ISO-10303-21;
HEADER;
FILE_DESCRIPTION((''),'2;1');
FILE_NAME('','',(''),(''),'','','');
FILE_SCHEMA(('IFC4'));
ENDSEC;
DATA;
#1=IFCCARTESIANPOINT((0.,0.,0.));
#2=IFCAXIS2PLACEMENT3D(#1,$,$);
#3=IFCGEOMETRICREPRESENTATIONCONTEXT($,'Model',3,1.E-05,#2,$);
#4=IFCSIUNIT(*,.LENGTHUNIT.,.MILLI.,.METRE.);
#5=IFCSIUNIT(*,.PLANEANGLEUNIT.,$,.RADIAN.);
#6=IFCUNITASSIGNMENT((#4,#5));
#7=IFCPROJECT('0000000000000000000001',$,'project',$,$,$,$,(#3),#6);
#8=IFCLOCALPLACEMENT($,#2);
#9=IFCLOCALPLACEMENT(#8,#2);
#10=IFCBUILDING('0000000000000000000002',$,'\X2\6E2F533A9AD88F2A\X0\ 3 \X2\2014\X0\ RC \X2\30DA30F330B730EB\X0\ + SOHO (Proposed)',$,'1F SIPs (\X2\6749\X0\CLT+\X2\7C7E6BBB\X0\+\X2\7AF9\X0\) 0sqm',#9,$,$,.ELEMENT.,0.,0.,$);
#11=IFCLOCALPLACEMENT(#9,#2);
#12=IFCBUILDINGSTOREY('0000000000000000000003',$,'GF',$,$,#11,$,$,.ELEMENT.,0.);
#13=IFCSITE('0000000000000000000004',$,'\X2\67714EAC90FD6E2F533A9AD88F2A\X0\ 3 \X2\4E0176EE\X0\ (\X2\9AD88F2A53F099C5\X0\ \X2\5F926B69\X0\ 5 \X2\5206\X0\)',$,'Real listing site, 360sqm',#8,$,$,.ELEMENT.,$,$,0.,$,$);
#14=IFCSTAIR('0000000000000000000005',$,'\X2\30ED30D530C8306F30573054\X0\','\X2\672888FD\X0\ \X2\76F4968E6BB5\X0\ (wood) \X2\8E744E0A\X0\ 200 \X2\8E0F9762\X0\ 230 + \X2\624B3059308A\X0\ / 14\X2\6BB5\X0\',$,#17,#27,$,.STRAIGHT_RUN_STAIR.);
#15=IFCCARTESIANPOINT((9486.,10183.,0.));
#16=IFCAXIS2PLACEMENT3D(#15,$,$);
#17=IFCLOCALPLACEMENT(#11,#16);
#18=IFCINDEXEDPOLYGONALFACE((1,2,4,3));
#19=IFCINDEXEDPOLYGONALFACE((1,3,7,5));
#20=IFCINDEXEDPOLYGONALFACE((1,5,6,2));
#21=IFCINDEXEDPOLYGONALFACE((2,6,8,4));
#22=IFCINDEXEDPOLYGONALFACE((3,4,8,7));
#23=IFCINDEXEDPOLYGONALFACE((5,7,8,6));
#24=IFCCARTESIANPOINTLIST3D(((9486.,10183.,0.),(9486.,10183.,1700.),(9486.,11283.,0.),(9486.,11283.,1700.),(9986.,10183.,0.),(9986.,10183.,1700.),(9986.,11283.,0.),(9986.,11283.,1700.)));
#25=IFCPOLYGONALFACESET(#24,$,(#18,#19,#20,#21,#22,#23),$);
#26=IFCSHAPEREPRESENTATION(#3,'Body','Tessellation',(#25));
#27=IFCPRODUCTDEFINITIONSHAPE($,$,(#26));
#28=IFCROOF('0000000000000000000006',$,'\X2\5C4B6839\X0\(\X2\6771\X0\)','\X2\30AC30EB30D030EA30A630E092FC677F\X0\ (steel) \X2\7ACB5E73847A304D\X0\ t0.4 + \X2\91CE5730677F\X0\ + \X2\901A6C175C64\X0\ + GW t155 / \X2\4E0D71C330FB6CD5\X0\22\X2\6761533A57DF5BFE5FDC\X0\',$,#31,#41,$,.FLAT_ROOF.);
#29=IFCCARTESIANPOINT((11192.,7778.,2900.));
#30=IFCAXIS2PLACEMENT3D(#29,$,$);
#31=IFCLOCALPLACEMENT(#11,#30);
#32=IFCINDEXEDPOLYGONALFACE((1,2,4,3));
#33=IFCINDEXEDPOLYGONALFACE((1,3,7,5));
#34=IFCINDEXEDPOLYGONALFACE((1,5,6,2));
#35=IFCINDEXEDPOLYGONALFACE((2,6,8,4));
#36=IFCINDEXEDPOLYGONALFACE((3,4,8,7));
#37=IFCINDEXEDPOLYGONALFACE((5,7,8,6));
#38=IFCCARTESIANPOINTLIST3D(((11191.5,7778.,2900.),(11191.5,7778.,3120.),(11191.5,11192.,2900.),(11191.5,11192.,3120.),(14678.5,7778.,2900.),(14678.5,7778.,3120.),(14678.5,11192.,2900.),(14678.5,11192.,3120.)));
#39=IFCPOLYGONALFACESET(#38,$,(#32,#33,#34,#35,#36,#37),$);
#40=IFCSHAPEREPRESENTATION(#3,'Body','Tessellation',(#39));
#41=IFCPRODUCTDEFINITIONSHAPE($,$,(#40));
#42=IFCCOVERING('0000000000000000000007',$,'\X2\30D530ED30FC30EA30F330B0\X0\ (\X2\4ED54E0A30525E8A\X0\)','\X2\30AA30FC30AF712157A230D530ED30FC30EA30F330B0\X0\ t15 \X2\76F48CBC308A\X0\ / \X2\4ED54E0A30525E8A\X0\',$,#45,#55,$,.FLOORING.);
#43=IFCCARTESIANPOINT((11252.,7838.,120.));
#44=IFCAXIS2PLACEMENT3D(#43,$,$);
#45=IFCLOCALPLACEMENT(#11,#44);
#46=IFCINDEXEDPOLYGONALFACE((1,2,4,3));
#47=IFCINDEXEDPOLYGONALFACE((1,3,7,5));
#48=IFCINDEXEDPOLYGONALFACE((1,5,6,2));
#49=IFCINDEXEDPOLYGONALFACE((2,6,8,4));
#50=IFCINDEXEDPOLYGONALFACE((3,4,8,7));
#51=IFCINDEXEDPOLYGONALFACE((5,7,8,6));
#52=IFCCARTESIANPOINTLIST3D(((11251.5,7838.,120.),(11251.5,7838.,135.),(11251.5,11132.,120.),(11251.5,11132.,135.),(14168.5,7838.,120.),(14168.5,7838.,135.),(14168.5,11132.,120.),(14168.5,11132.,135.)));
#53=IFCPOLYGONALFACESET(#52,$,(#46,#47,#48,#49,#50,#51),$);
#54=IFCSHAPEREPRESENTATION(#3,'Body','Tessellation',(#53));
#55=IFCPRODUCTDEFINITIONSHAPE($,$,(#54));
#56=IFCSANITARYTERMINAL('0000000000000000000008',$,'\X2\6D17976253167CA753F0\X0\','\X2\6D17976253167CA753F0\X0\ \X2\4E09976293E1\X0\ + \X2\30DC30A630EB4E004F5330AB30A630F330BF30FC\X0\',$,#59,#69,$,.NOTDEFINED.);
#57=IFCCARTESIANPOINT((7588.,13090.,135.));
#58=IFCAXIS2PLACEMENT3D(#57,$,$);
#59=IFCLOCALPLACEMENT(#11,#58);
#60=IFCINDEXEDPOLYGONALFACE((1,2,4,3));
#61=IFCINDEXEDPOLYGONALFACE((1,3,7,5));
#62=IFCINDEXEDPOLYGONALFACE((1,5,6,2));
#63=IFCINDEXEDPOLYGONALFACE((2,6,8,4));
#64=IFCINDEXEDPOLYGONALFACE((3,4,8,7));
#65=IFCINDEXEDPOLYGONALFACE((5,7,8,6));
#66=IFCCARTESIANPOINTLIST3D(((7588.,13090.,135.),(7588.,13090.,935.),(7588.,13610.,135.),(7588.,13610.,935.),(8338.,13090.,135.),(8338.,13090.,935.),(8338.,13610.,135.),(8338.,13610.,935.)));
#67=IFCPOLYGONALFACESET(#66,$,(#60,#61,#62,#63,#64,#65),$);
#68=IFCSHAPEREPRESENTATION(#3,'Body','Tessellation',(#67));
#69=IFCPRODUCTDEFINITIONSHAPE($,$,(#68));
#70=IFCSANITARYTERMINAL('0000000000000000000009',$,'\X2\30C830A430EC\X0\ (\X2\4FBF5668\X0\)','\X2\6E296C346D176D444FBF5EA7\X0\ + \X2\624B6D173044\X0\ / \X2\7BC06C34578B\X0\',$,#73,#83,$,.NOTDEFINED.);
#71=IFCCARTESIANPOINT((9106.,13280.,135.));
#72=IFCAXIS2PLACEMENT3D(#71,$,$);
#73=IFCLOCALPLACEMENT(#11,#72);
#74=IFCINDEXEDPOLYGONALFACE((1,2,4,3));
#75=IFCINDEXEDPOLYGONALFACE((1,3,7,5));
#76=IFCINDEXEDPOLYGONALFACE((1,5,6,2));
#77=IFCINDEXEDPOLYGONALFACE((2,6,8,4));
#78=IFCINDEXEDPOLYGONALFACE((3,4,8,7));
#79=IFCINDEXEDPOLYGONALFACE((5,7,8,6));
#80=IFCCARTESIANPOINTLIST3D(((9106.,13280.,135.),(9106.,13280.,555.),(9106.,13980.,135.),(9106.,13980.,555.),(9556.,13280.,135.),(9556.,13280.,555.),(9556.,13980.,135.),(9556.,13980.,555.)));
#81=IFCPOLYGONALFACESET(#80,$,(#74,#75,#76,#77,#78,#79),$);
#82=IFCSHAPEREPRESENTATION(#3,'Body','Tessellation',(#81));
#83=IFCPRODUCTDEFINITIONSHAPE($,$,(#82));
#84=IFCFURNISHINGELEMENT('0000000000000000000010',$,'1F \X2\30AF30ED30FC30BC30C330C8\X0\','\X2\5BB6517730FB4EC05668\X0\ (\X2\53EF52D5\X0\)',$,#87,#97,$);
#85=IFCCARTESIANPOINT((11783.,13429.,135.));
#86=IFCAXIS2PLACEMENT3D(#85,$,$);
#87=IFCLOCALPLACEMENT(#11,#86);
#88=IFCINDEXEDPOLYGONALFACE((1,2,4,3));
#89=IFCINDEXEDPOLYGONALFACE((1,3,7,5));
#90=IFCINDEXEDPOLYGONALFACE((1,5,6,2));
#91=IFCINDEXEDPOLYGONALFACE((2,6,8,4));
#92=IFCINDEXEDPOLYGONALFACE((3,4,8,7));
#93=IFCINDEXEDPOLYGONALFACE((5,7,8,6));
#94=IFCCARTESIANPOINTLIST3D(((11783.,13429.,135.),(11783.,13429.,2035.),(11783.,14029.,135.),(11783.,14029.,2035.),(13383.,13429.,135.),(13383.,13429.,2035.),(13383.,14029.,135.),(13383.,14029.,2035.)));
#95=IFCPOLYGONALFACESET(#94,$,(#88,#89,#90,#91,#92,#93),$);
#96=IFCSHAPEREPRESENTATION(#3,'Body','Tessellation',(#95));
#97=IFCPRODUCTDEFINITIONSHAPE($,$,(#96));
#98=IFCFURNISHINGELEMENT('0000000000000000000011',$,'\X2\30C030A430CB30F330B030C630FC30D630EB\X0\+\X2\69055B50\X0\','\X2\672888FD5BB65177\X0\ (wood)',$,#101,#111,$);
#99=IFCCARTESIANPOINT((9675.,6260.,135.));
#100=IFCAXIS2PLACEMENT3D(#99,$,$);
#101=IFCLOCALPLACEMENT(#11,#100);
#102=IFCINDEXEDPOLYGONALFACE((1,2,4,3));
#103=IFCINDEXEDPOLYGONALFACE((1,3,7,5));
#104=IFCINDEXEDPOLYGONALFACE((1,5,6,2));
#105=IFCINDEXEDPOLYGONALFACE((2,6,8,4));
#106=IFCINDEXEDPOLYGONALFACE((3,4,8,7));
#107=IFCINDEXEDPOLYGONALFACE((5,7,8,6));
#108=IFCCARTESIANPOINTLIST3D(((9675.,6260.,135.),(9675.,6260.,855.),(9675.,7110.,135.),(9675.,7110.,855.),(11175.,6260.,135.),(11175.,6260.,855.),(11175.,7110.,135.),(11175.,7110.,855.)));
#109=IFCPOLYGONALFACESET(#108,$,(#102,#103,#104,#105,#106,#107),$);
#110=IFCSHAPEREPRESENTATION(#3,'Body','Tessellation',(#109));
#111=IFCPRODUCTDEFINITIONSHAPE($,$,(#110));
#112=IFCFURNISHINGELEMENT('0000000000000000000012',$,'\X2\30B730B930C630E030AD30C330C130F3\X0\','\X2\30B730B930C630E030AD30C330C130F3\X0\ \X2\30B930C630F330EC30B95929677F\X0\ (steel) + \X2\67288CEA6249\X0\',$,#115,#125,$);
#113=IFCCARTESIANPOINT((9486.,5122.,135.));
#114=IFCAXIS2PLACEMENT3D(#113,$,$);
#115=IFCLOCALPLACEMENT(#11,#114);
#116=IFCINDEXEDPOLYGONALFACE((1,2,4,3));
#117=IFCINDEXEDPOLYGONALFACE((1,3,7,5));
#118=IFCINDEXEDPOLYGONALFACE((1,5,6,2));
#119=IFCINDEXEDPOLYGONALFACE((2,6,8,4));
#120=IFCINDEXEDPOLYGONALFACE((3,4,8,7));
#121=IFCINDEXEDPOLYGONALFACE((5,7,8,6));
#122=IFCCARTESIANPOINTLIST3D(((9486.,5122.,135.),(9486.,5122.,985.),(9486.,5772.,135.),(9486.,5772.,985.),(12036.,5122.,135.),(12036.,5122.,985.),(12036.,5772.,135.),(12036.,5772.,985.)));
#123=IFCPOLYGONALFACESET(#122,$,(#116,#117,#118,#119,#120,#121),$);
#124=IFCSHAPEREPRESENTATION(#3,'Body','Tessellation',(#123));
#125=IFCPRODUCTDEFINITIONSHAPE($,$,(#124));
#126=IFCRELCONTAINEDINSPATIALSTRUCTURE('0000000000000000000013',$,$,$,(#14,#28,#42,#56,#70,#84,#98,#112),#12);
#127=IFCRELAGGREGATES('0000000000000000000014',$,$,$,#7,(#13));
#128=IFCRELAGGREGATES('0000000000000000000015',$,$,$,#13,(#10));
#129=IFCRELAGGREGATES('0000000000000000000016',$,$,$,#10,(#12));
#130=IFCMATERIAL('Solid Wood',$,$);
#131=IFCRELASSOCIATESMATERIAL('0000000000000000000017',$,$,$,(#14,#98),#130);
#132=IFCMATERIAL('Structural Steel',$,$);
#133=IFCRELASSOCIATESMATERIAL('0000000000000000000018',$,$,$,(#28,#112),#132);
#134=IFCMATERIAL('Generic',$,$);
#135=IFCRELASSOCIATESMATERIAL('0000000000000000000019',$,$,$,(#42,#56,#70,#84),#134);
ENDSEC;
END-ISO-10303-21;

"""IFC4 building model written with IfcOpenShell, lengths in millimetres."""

from ifc_helpers import new_model, si_unit, frame, frame_2d, origin, place, context, project, spatial, rectangle, extrude, material, element, save


model = new_model("IFC4")

# Units and contexts
model_context = context("Model", 3, precision=1e-05, world=origin())
ifc_project = project(units=[si_unit("LENGTHUNIT", "METRE", prefix="MILLI"), si_unit("PLANEANGLEUNIT", "RADIAN")], contexts=[model_context])

# Site, building, storey
site_placement = place(None, origin())
site = spatial("IfcSite", under=ifc_project, at=site_placement, Name="東京都港区高輪 3 丁目 (高輪台駅 徒歩 5 分)", ObjectType="Real listing site, 360sqm", CompositionType="ELEMENT", RefElevation=0.0)
building_placement = place(site_placement, origin())
building = spatial("IfcBuilding", under=site, at=building_placement, Name="港区高輪 3 — RC ペンシル + SOHO (Proposed)", ObjectType="1F SIPs (杉CLT+籾殻+竹) 0sqm", CompositionType="ELEMENT", ElevationOfRefHeight=0.0, ElevationOfTerrain=0.0)
storey_placement = place(building_placement, origin())
storey = spatial("IfcBuildingStorey", under=building, at=storey_placement, Name="GF", CompositionType="ELEMENT", Elevation=0.0)

# Shared definitions
ifc_material_1 = material(Name="Solid Wood")

# Stair
stair_placement = place(storey_placement, frame((9486.0, 10183.0, 0.0)))
element("IfcStair", 1, at=stair_placement, inside=storey, material=ifc_material_1, Name="ロフトはしご", Description="木製 直階段 (wood) 蹴上 200 踏面 230 + 手すり / 14段", PredefinedType="STRAIGHT_RUN_STAIR", context=model_context, shape_type="SweptSolid", body=[
    extrude(rectangle(XDim=500.0, YDim=1100.0, at=frame_2d((250.0, 550.0))), frame((9486.0, 10183.0, 0.0)), (0.0, 0.0, 1.0), 1700.0),
])

# Roof
ifc_material_2 = material(Name="Structural Steel")
roof_placement = place(storey_placement, frame((11192.0, 7778.0, 2900.0)))
element("IfcRoof", 2, at=roof_placement, inside=storey, material=ifc_material_2, Name="屋根(東)", Description="ガルバリウム鋼板 (steel) 立平葺き t0.4 + 野地板 + 通気層 + GW t155 / 不燃・法22条区域対応", PredefinedType="FLAT_ROOF", context=model_context, shape_type="SweptSolid", body=[
    extrude(rectangle(XDim=3487.0, YDim=3414.0, at=frame_2d((1743.0, 1707.0))), frame((11192.0, 7778.0, 2900.0)), (0.0, 0.0, 1.0), 220.0),
])

# Covering
ifc_material_3 = material(Name="Generic")
covering_placement = place(storey_placement, frame((11252.0, 7838.0, 120.0)))
element("IfcCovering", 3, at=covering_placement, inside=storey, material=ifc_material_3, Name="フローリング (仕上げ床)", Description="オーク無垢フローリング t15 直貼り / 仕上げ床", PredefinedType="FLOORING", context=model_context, shape_type="SweptSolid", body=[
    extrude(rectangle(XDim=2917.0, YDim=3294.0, at=frame_2d((1458.0, 1647.0))), frame((11252.0, 7838.0, 120.0)), (0.0, 0.0, 1.0), 15.0),
])

# Sanitary terminals
sanitary_terminal_1_placement = place(storey_placement, frame((7588.0, 13090.0, 135.0)))
element("IfcSanitaryTerminal", 4, at=sanitary_terminal_1_placement, inside=storey, material=ifc_material_3, Name="洗面化粧台", Description="洗面化粧台 三面鏡 + ボウル一体カウンター", PredefinedType="NOTDEFINED", context=model_context, shape_type="SweptSolid", body=[
    extrude(rectangle(XDim=750.0, YDim=520.0, at=frame_2d((375.0, 260.0))), frame((7588.0, 13090.0, 135.0)), (0.0, 0.0, 1.0), 800.0),
])
sanitary_terminal_2_placement = place(storey_placement, frame((9106.0, 13280.0, 135.0)))
element("IfcSanitaryTerminal", 5, at=sanitary_terminal_2_placement, inside=storey, material=ifc_material_3, Name="トイレ (便器)", Description="温水洗浄便座 + 手洗い / 節水型", PredefinedType="NOTDEFINED", context=model_context, shape_type="SweptSolid", body=[
    extrude(rectangle(XDim=450.0, YDim=700.0, at=frame_2d((225.0, 350.0))), frame((9106.0, 13280.0, 135.0)), (0.0, 0.0, 1.0), 420.0),
])

# Furnishing elements
furnishing_1_placement = place(storey_placement, frame((11783.0, 13429.0, 135.0)))
element("IfcFurnishingElement", 6, at=furnishing_1_placement, inside=storey, material=ifc_material_3, Name="1F クローゼット", Description="家具・什器 (可動)", context=model_context, shape_type="SweptSolid", body=[
    extrude(rectangle(XDim=1600.0, YDim=600.0, at=frame_2d((800.0, 300.0))), frame((11783.0, 13429.0, 135.0)), (0.0, 0.0, 1.0), 1900.0),
])
furnishing_2_placement = place(storey_placement, frame((9675.0, 6260.0, 135.0)))
element("IfcFurnishingElement", 7, at=furnishing_2_placement, inside=storey, material=ifc_material_1, Name="ダイニングテーブル+椅子", Description="木製家具 (wood)", context=model_context, shape_type="SweptSolid", body=[
    extrude(rectangle(XDim=1500.0, YDim=850.0, at=frame_2d((750.0, 425.0))), frame((9675.0, 6260.0, 135.0)), (0.0, 0.0, 1.0), 720.0),
])
furnishing_3_placement = place(storey_placement, frame((9486.0, 5122.0, 135.0)))
element("IfcFurnishingElement", 8, at=furnishing_3_placement, inside=storey, material=ifc_material_2, Name="システムキッチン", Description="システムキッチン ステンレス天板 (steel) + 木質扉", context=model_context, shape_type="SweptSolid", body=[
    extrude(rectangle(XDim=2550.0, YDim=650.0, at=frame_2d((1275.0, 325.0))), frame((9486.0, 5122.0, 135.0)), (0.0, 0.0, 1.0), 850.0),
])

save(model, "model.ifc")
